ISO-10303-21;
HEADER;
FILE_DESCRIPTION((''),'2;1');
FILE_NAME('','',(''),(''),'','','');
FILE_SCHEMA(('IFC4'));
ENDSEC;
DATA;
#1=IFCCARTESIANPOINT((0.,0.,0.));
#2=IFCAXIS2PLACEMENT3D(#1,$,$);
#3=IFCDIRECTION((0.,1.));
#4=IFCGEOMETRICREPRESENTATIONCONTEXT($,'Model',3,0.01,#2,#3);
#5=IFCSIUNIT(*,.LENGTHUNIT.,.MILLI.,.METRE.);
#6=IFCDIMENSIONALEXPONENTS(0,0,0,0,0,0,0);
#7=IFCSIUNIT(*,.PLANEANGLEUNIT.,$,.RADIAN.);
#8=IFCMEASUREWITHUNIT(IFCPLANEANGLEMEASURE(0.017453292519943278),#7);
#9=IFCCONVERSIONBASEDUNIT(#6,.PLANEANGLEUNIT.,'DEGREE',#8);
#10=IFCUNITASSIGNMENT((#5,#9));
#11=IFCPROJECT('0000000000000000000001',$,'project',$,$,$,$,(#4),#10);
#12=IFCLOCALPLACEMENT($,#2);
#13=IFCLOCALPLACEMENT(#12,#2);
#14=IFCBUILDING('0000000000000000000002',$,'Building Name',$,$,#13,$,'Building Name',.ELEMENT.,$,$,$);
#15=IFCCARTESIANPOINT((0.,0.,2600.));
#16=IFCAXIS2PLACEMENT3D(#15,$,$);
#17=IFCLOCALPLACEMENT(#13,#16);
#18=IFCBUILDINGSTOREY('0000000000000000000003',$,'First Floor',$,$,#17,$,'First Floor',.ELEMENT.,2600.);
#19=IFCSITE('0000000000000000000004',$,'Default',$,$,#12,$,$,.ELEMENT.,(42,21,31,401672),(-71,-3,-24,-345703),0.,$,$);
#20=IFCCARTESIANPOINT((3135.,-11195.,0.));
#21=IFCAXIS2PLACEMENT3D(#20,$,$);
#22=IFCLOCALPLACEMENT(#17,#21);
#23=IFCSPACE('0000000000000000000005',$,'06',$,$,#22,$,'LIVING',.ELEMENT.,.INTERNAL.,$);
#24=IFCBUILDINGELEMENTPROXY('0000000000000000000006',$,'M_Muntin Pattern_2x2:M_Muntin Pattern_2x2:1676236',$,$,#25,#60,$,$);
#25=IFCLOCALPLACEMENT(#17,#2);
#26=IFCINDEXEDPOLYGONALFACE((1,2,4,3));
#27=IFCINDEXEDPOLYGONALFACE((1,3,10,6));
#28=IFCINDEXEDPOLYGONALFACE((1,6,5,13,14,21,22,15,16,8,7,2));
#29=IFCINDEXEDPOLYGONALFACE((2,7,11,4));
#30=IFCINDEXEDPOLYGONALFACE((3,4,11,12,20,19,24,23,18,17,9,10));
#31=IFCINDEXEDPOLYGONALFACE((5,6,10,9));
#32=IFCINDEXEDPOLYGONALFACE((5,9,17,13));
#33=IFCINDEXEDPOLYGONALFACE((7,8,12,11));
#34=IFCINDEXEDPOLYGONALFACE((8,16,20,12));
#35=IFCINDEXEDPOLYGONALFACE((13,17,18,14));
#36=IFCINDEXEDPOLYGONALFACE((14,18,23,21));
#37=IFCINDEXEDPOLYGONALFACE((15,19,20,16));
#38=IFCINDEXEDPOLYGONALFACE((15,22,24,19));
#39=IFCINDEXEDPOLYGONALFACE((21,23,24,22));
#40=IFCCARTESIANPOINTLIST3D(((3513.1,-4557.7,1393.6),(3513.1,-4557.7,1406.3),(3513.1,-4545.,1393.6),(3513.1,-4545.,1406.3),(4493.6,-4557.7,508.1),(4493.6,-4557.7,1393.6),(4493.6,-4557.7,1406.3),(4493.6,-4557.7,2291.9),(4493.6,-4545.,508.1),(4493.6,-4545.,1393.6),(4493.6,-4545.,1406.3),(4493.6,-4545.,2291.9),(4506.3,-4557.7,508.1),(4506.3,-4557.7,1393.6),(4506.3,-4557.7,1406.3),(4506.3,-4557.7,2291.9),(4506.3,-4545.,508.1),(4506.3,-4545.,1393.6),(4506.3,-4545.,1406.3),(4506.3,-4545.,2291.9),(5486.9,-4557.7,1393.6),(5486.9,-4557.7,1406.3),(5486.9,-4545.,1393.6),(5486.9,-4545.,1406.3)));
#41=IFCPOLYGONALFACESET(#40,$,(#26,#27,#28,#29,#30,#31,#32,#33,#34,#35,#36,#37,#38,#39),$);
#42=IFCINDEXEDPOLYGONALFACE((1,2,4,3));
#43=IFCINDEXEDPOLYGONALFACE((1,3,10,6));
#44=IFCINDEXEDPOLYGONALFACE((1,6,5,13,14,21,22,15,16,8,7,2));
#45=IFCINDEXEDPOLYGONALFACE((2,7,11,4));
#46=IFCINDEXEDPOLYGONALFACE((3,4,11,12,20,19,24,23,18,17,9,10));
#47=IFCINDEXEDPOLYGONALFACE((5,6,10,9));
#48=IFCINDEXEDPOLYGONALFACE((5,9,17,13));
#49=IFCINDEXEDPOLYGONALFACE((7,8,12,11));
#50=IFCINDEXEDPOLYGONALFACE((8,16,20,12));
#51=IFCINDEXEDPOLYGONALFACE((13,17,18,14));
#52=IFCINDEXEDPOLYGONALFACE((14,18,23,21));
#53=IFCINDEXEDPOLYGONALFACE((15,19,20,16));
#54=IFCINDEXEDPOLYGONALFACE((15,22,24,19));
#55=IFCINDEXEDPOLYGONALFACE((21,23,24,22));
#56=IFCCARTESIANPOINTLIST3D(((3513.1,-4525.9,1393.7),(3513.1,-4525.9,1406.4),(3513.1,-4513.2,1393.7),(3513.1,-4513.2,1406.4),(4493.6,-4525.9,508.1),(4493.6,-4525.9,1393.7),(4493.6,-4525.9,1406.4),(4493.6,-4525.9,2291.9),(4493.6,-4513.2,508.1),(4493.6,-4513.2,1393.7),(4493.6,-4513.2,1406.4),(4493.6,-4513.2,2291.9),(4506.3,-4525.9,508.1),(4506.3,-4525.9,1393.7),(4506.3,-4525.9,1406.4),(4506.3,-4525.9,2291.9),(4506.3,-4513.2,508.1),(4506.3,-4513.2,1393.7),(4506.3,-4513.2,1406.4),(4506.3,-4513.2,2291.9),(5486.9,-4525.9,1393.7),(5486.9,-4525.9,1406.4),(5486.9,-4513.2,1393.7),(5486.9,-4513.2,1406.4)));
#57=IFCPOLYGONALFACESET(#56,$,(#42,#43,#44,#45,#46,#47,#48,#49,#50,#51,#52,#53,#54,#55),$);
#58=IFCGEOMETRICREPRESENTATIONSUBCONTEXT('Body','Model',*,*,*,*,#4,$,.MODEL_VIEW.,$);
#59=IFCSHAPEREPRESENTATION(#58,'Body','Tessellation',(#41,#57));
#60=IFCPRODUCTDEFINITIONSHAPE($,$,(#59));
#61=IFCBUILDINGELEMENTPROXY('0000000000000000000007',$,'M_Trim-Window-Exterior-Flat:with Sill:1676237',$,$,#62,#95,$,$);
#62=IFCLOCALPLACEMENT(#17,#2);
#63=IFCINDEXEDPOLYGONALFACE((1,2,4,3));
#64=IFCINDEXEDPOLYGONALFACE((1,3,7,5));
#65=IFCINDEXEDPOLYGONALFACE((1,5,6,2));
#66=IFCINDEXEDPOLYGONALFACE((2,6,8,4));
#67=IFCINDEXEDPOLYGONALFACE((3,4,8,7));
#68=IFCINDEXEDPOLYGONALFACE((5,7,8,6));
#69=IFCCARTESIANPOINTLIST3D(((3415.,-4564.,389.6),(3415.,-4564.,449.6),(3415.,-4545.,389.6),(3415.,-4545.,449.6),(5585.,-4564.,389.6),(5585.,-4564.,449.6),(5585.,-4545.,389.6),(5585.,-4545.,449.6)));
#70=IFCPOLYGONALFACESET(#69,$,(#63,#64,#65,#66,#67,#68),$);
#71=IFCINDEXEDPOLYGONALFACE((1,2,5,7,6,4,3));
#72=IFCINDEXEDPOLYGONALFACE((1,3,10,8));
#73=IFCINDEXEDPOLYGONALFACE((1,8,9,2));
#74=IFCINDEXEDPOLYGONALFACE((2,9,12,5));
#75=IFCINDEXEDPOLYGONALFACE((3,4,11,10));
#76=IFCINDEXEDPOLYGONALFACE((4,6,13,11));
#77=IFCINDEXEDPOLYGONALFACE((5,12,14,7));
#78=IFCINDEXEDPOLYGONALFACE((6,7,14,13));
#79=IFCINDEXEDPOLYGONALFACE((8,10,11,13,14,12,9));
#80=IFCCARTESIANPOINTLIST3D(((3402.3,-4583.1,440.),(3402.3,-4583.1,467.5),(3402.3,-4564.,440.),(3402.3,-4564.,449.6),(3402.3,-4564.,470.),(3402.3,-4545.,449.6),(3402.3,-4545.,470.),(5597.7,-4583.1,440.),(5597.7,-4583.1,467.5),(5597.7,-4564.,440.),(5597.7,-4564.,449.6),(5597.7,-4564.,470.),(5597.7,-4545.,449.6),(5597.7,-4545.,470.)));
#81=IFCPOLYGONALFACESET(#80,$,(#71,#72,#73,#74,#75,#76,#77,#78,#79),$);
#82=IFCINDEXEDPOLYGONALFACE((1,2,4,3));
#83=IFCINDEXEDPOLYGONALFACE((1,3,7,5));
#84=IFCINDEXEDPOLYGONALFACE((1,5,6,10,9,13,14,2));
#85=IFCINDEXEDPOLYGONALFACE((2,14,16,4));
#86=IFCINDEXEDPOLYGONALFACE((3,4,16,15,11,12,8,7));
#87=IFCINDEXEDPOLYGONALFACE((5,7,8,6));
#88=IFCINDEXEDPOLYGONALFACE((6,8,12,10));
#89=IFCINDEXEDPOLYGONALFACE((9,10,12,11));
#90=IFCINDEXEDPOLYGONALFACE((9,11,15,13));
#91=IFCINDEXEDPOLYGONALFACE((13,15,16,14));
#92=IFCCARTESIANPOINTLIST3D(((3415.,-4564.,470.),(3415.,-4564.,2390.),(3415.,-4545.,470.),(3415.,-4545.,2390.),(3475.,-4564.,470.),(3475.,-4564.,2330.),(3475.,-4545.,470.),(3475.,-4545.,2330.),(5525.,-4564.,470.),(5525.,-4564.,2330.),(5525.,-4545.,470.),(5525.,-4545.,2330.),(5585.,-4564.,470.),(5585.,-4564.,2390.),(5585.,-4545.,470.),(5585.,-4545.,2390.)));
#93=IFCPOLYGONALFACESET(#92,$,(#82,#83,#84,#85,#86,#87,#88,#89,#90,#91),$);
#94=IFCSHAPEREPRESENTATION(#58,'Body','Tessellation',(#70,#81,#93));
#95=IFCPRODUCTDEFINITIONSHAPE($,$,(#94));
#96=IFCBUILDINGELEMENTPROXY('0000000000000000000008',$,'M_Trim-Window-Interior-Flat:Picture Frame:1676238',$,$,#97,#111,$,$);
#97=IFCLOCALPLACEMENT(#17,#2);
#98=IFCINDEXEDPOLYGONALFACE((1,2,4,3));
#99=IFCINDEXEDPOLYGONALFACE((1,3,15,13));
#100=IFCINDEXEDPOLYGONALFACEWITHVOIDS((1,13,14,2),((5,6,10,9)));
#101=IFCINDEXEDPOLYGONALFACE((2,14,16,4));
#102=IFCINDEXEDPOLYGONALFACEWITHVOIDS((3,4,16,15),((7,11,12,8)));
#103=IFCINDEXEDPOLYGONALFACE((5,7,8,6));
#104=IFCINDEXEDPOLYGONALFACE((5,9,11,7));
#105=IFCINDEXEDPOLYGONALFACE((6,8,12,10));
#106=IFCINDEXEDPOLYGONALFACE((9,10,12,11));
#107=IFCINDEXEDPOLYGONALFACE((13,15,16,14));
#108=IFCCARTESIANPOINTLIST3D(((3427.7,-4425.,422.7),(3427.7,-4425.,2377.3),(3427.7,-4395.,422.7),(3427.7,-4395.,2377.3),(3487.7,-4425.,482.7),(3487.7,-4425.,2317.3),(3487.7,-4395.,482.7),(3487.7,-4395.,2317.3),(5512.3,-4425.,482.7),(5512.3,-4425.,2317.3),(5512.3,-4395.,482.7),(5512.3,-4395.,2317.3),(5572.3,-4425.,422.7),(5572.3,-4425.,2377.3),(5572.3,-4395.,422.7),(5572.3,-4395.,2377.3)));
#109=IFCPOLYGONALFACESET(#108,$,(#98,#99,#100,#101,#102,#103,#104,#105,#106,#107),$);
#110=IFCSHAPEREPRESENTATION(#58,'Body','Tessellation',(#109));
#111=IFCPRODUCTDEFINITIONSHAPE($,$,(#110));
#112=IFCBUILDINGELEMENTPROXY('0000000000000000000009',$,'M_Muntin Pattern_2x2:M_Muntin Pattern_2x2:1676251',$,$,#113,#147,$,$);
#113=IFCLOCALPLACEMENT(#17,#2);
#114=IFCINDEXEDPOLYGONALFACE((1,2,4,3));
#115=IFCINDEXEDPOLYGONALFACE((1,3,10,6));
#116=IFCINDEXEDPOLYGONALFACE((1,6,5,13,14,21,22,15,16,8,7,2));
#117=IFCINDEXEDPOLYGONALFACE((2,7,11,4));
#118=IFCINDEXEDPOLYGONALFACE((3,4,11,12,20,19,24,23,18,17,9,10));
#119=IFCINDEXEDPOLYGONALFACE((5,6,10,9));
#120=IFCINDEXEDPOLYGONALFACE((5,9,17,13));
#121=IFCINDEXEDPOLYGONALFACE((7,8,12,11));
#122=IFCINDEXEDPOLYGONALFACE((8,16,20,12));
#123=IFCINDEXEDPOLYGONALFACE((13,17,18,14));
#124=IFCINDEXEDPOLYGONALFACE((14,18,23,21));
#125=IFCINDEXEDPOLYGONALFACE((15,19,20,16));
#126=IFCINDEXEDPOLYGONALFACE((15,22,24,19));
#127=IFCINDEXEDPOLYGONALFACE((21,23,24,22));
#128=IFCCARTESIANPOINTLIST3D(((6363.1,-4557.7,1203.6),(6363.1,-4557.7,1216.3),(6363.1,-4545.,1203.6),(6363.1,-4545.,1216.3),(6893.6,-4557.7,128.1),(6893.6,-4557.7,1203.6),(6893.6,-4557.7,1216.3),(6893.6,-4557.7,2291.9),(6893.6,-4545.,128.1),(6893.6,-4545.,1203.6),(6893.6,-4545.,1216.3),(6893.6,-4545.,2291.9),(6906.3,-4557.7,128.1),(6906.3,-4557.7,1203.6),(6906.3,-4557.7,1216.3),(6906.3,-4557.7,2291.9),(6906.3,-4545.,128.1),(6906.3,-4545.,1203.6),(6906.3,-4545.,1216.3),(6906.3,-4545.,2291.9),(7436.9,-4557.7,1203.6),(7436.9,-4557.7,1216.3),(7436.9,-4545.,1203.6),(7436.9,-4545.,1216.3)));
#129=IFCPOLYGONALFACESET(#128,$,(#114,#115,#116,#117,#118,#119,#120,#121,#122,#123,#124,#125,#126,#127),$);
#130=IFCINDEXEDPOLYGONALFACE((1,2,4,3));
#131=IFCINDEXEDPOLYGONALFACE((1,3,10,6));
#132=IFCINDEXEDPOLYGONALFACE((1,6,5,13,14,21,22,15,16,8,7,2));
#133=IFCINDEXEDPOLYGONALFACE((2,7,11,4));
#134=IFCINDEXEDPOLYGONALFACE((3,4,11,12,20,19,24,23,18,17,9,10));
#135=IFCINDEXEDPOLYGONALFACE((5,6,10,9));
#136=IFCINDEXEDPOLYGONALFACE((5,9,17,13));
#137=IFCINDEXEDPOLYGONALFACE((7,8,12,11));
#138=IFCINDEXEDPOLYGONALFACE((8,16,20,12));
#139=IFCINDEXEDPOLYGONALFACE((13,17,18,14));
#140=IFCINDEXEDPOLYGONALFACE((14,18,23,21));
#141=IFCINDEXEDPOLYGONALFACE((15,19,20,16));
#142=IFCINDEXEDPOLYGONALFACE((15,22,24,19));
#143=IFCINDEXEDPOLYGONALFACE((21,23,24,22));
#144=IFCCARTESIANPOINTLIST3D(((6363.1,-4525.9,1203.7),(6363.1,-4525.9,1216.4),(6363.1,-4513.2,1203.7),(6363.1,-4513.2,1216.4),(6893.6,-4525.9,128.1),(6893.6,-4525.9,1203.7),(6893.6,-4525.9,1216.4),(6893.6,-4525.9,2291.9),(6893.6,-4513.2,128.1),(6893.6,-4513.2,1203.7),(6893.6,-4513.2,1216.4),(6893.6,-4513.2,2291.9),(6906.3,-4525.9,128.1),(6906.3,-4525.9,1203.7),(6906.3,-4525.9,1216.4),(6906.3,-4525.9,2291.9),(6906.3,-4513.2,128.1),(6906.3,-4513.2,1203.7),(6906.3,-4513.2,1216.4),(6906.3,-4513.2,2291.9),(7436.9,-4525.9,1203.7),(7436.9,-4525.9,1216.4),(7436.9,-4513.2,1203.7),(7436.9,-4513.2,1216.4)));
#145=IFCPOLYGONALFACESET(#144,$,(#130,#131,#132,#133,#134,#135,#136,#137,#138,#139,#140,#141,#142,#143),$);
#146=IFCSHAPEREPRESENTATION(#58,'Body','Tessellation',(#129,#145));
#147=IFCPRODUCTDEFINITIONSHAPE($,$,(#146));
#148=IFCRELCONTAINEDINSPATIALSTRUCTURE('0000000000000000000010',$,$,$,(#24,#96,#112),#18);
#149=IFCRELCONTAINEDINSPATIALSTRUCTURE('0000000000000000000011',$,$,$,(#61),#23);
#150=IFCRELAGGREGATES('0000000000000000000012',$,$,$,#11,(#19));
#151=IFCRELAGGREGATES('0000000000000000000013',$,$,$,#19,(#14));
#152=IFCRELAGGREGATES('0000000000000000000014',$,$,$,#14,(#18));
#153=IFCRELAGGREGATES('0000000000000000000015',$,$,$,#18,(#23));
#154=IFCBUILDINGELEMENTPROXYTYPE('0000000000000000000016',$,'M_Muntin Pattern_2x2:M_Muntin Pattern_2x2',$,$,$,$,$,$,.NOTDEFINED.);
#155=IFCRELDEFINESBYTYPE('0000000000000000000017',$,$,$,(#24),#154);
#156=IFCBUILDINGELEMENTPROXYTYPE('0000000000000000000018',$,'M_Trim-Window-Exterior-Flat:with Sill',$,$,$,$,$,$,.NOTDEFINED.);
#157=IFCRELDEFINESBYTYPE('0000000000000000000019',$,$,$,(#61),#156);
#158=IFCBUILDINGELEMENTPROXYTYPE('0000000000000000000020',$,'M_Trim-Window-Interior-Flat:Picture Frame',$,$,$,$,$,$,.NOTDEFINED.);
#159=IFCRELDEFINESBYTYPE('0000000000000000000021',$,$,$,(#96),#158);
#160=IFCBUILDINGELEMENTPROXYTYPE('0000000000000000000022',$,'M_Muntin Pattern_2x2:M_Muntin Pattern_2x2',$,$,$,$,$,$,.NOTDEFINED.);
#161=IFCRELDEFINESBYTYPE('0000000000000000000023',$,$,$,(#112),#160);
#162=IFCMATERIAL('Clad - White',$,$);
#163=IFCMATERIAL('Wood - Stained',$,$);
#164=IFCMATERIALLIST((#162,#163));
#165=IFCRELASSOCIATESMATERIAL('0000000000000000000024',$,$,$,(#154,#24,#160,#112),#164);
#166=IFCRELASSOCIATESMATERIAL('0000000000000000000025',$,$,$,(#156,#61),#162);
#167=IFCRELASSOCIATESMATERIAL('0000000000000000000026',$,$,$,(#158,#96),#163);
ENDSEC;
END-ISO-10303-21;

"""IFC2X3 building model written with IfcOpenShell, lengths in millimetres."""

from ifc_helpers import new_model, entity, si_unit, converted_unit, direction, frame, frame_2d, origin, place, context, subcontext, project, spatial, polyline, rectangle, outline, extrude, source, transform, mapped, material, material_list, type_object, type_shapes, element, save


model = new_model("IFC2X3")

# Units and contexts
model_context = context("Model", 3, precision=0.01, world=origin(), true_north=direction((0.0, 1.0)))
body_context = subcontext(model_context, "Body", "Model", "MODEL_VIEW")
ifc_project = project(units=[si_unit("LENGTHUNIT", "METRE", prefix="MILLI"), converted_unit("PLANEANGLEUNIT", "DEGREE", entity("IfcPlaneAngleMeasure", 0.017453292519943278), si_unit("PLANEANGLEUNIT", "RADIAN"), dimensions=[0, 0, 0, 0, 0, 0, 0])], contexts=[model_context])

# Site, building, storey
site_placement = place(None, origin())
site = spatial("IfcSite", under=ifc_project, at=site_placement, Name="Default", CompositionType="ELEMENT", RefLatitude=(42, 21, 31, 401672), RefLongitude=(-71, -3, -24, -345703), RefElevation=0.0)
building_placement = place(site_placement, origin())
building = spatial("IfcBuilding", under=site, at=building_placement, Name="Building Name", LongName="Building Name", CompositionType="ELEMENT")
storey_placement = place(building_placement, frame((0.0, 0.0, 2600.0)))
storey = spatial("IfcBuildingStorey", under=building, at=storey_placement, Name="First Floor", LongName="First Floor", CompositionType="ELEMENT", Elevation=2600.0)

# Shared definitions
space_1_placement = place(storey_placement, frame((3135.0, -11195.0, 0.0)))
space_1 = spatial("IfcSpace", under=storey, at=space_1_placement, Name="06", LongName="LIVING", CompositionType="ELEMENT", InteriorOrExteriorSpace="INTERNAL")

# Building element proxies
ifc_material_1 = material(Name="Clad - White")
ifc_material_2 = material(Name="Wood - Stained")
ifc_material_list_1 = material_list([ifc_material_1, ifc_material_2])
building_element_proxy_type_1 = type_object("IfcBuildingElementProxyType", Name="M_Muntin Pattern_2x2:M_Muntin Pattern_2x2", PredefinedType="NOTDEFINED", material=ifc_material_list_1)
shared_shape_1 = source(origin(), body_context, "Body", "SweptSolid", [
    extrude(outline(polyline([(6.4, -6.4), (891.9, -6.4), (891.9, 6.3), (6.4, 6.3), (6.4, 986.9), (-6.3, 986.9), (-6.3, 6.3), (-891.9, 6.3), (-891.9, -6.4), (-6.3, -6.4), (-6.3, -986.9), (6.4, -986.9), (6.4, -6.4)])), frame((0.0, -22.2, 891.9), z_axis=(0.0, 1.0, 0.0), x_axis=(0.0, 0.0, 1.0)), (0.0, 0.0, 1.0), 12.7),
    extrude(outline(polyline([(6.4, -6.4), (891.9, -6.4), (891.9, 6.3), (6.4, 6.3), (6.4, 986.9), (-6.3, 986.9), (-6.3, 6.3), (-891.9, 6.3), (-891.9, -6.4), (-6.3, -6.4), (-6.3, -986.9), (6.4, -986.9), (6.4, -6.4)])), frame((0.0, 9.5, 891.9), z_axis=(0.0, 1.0, 0.0), x_axis=(0.0, 0.0, 1.0)), (0.0, 0.0, 1.0), 12.7),
])
type_shapes(building_element_proxy_type_1, [shared_shape_1])
proxy_1_placement = place(storey_placement, frame((4500.0, -4535.5, 508.1)))
element("IfcBuildingElementProxy", 1, at=proxy_1_placement, inside=storey, type_object=building_element_proxy_type_1, material=ifc_material_list_1, Name="M_Muntin Pattern_2x2:M_Muntin Pattern_2x2:1676236", context=body_context, shape_type="MappedRepresentation", body=[
    mapped(shared_shape_1, transform((0.0, 0.0, 0.0), scale=1.0)),
])
building_element_proxy_type_2 = type_object("IfcBuildingElementProxyType", Name="M_Trim-Window-Exterior-Flat:with Sill", PredefinedType="NOTDEFINED", material=ifc_material_1)
shared_shape_2 = source(origin(), body_context, "Body", "SweptSolid", [
    extrude(rectangle(XDim=2170.0, YDim=60.0, at=frame_2d((0.0, 0.0), x_axis=(1.0, 0.0))), frame((0.0, -1910.4, 0.0), z_axis=(0.0, 0.0, 1.0), x_axis=(-1.0, 0.0, 0.0)), (0.0, 0.0, 1.0), 19.0),
    extrude(outline(polyline([(-19.0, -15.2), (0.0, -15.2), (0.0, -5.7), (19.0, -5.7), (19.0, 14.8), (0.0, 14.8), (-19.0, 12.3), (-19.0, -15.2)])), frame((-1097.7, -1874.8, 19.0), z_axis=(1.0, 0.0, 0.0), x_axis=(0.0, 0.0, -1.0)), (0.0, 0.0, 1.0), 2195.4),
    extrude(outline(polyline([(-975.0, -1085.0), (945.0, -1085.0), (945.0, -1025.0), (-915.0, -1025.0), (-915.0, 1025.0), (945.0, 1025.0), (945.0, 1085.0), (-975.0, 1085.0), (-975.0, -1085.0)])), frame((0.0, -915.0, 0.0), z_axis=(0.0, 0.0, 1.0), x_axis=(0.0, -1.0, 0.0)), (0.0, 0.0, 1.0), 19.0),
])
type_shapes(building_element_proxy_type_2, [shared_shape_2])
proxy_2_placement = place(space_1_placement, frame((1365.0, 6650.0, 2330.0), z_axis=(0.0, -1.0, 0.0), x_axis=(1.0, 0.0, 0.0)))
element("IfcBuildingElementProxy", 2, at=proxy_2_placement, inside=space_1, type_object=building_element_proxy_type_2, material=ifc_material_1, Name="M_Trim-Window-Exterior-Flat:with Sill:1676237", context=body_context, shape_type="MappedRepresentation", body=[
    mapped(shared_shape_2, transform((0.0, 0.0, 0.0), scale=1.0)),
])
building_element_proxy_type_3 = type_object("IfcBuildingElementProxyType", Name="M_Trim-Window-Interior-Flat:Picture Frame", PredefinedType="NOTDEFINED", material=ifc_material_2)
shared_shape_3 = source(origin(), body_context, "Body", "SweptSolid", [
    extrude(outline(polyline([(-1072.3, -977.3), (1072.3, -977.3), (1072.3, 977.3), (-1072.3, 977.3), (-1072.3, -977.3)]), holes=[polyline([(-1012.3, -917.3), (-1012.3, 917.3), (1012.3, 917.3), (1012.3, -917.3), (-1012.3, -917.3)])]), frame((0.0, -930.0, 0.0), z_axis=(0.0, 0.0, 1.0), x_axis=(-1.0, 0.0, 0.0)), (0.0, 0.0, 1.0), 30.0),
])
type_shapes(building_element_proxy_type_3, [shared_shape_3])
proxy_3_placement = place(storey_placement, frame((4500.0, -4425.0, 2330.0), z_axis=(0.0, 1.0, 0.0), x_axis=(-1.0, 0.0, 0.0)))
element("IfcBuildingElementProxy", 3, at=proxy_3_placement, inside=storey, type_object=building_element_proxy_type_3, material=ifc_material_2, Name="M_Trim-Window-Interior-Flat:Picture Frame:1676238", context=body_context, shape_type="MappedRepresentation", body=[
    mapped(shared_shape_3, transform((0.0, 0.0, 0.0), scale=1.0)),
])
building_element_proxy_type_4 = type_object("IfcBuildingElementProxyType", Name="M_Muntin Pattern_2x2:M_Muntin Pattern_2x2", PredefinedType="NOTDEFINED", material=ifc_material_list_1)
shared_shape_4 = source(origin(), body_context, "Body", "SweptSolid", [
    extrude(outline(polyline([(6.4, -6.4), (1081.9, -6.4), (1081.9, 6.3), (6.4, 6.3), (6.4, 536.9), (-6.3, 536.9), (-6.3, 6.3), (-1081.9, 6.3), (-1081.9, -6.4), (-6.3, -6.4), (-6.3, -536.9), (6.4, -536.9), (6.4, -6.4)])), frame((0.0, -22.2, 1081.9), z_axis=(0.0, 1.0, 0.0), x_axis=(0.0, 0.0, 1.0)), (0.0, 0.0, 1.0), 12.7),
    extrude(outline(polyline([(6.4, -6.4), (1081.9, -6.4), (1081.9, 6.3), (6.4, 6.3), (6.4, 536.9), (-6.3, 536.9), (-6.3, 6.3), (-1081.9, 6.3), (-1081.9, -6.4), (-6.3, -6.4), (-6.3, -536.9), (6.4, -536.9), (6.4, -6.4)])), frame((0.0, 9.5, 1081.9), z_axis=(0.0, 1.0, 0.0), x_axis=(0.0, 0.0, 1.0)), (0.0, 0.0, 1.0), 12.7),
])
type_shapes(building_element_proxy_type_4, [shared_shape_4])
proxy_4_placement = place(storey_placement, frame((6900.0, -4535.5, 128.1)))
element("IfcBuildingElementProxy", 4, at=proxy_4_placement, inside=storey, type_object=building_element_proxy_type_4, material=ifc_material_list_1, Name="M_Muntin Pattern_2x2:M_Muntin Pattern_2x2:1676251", context=body_context, shape_type="MappedRepresentation", body=[
    mapped(shared_shape_4, transform((0.0, 0.0, 0.0), scale=1.0)),
])

save(model, "model.ifc")
